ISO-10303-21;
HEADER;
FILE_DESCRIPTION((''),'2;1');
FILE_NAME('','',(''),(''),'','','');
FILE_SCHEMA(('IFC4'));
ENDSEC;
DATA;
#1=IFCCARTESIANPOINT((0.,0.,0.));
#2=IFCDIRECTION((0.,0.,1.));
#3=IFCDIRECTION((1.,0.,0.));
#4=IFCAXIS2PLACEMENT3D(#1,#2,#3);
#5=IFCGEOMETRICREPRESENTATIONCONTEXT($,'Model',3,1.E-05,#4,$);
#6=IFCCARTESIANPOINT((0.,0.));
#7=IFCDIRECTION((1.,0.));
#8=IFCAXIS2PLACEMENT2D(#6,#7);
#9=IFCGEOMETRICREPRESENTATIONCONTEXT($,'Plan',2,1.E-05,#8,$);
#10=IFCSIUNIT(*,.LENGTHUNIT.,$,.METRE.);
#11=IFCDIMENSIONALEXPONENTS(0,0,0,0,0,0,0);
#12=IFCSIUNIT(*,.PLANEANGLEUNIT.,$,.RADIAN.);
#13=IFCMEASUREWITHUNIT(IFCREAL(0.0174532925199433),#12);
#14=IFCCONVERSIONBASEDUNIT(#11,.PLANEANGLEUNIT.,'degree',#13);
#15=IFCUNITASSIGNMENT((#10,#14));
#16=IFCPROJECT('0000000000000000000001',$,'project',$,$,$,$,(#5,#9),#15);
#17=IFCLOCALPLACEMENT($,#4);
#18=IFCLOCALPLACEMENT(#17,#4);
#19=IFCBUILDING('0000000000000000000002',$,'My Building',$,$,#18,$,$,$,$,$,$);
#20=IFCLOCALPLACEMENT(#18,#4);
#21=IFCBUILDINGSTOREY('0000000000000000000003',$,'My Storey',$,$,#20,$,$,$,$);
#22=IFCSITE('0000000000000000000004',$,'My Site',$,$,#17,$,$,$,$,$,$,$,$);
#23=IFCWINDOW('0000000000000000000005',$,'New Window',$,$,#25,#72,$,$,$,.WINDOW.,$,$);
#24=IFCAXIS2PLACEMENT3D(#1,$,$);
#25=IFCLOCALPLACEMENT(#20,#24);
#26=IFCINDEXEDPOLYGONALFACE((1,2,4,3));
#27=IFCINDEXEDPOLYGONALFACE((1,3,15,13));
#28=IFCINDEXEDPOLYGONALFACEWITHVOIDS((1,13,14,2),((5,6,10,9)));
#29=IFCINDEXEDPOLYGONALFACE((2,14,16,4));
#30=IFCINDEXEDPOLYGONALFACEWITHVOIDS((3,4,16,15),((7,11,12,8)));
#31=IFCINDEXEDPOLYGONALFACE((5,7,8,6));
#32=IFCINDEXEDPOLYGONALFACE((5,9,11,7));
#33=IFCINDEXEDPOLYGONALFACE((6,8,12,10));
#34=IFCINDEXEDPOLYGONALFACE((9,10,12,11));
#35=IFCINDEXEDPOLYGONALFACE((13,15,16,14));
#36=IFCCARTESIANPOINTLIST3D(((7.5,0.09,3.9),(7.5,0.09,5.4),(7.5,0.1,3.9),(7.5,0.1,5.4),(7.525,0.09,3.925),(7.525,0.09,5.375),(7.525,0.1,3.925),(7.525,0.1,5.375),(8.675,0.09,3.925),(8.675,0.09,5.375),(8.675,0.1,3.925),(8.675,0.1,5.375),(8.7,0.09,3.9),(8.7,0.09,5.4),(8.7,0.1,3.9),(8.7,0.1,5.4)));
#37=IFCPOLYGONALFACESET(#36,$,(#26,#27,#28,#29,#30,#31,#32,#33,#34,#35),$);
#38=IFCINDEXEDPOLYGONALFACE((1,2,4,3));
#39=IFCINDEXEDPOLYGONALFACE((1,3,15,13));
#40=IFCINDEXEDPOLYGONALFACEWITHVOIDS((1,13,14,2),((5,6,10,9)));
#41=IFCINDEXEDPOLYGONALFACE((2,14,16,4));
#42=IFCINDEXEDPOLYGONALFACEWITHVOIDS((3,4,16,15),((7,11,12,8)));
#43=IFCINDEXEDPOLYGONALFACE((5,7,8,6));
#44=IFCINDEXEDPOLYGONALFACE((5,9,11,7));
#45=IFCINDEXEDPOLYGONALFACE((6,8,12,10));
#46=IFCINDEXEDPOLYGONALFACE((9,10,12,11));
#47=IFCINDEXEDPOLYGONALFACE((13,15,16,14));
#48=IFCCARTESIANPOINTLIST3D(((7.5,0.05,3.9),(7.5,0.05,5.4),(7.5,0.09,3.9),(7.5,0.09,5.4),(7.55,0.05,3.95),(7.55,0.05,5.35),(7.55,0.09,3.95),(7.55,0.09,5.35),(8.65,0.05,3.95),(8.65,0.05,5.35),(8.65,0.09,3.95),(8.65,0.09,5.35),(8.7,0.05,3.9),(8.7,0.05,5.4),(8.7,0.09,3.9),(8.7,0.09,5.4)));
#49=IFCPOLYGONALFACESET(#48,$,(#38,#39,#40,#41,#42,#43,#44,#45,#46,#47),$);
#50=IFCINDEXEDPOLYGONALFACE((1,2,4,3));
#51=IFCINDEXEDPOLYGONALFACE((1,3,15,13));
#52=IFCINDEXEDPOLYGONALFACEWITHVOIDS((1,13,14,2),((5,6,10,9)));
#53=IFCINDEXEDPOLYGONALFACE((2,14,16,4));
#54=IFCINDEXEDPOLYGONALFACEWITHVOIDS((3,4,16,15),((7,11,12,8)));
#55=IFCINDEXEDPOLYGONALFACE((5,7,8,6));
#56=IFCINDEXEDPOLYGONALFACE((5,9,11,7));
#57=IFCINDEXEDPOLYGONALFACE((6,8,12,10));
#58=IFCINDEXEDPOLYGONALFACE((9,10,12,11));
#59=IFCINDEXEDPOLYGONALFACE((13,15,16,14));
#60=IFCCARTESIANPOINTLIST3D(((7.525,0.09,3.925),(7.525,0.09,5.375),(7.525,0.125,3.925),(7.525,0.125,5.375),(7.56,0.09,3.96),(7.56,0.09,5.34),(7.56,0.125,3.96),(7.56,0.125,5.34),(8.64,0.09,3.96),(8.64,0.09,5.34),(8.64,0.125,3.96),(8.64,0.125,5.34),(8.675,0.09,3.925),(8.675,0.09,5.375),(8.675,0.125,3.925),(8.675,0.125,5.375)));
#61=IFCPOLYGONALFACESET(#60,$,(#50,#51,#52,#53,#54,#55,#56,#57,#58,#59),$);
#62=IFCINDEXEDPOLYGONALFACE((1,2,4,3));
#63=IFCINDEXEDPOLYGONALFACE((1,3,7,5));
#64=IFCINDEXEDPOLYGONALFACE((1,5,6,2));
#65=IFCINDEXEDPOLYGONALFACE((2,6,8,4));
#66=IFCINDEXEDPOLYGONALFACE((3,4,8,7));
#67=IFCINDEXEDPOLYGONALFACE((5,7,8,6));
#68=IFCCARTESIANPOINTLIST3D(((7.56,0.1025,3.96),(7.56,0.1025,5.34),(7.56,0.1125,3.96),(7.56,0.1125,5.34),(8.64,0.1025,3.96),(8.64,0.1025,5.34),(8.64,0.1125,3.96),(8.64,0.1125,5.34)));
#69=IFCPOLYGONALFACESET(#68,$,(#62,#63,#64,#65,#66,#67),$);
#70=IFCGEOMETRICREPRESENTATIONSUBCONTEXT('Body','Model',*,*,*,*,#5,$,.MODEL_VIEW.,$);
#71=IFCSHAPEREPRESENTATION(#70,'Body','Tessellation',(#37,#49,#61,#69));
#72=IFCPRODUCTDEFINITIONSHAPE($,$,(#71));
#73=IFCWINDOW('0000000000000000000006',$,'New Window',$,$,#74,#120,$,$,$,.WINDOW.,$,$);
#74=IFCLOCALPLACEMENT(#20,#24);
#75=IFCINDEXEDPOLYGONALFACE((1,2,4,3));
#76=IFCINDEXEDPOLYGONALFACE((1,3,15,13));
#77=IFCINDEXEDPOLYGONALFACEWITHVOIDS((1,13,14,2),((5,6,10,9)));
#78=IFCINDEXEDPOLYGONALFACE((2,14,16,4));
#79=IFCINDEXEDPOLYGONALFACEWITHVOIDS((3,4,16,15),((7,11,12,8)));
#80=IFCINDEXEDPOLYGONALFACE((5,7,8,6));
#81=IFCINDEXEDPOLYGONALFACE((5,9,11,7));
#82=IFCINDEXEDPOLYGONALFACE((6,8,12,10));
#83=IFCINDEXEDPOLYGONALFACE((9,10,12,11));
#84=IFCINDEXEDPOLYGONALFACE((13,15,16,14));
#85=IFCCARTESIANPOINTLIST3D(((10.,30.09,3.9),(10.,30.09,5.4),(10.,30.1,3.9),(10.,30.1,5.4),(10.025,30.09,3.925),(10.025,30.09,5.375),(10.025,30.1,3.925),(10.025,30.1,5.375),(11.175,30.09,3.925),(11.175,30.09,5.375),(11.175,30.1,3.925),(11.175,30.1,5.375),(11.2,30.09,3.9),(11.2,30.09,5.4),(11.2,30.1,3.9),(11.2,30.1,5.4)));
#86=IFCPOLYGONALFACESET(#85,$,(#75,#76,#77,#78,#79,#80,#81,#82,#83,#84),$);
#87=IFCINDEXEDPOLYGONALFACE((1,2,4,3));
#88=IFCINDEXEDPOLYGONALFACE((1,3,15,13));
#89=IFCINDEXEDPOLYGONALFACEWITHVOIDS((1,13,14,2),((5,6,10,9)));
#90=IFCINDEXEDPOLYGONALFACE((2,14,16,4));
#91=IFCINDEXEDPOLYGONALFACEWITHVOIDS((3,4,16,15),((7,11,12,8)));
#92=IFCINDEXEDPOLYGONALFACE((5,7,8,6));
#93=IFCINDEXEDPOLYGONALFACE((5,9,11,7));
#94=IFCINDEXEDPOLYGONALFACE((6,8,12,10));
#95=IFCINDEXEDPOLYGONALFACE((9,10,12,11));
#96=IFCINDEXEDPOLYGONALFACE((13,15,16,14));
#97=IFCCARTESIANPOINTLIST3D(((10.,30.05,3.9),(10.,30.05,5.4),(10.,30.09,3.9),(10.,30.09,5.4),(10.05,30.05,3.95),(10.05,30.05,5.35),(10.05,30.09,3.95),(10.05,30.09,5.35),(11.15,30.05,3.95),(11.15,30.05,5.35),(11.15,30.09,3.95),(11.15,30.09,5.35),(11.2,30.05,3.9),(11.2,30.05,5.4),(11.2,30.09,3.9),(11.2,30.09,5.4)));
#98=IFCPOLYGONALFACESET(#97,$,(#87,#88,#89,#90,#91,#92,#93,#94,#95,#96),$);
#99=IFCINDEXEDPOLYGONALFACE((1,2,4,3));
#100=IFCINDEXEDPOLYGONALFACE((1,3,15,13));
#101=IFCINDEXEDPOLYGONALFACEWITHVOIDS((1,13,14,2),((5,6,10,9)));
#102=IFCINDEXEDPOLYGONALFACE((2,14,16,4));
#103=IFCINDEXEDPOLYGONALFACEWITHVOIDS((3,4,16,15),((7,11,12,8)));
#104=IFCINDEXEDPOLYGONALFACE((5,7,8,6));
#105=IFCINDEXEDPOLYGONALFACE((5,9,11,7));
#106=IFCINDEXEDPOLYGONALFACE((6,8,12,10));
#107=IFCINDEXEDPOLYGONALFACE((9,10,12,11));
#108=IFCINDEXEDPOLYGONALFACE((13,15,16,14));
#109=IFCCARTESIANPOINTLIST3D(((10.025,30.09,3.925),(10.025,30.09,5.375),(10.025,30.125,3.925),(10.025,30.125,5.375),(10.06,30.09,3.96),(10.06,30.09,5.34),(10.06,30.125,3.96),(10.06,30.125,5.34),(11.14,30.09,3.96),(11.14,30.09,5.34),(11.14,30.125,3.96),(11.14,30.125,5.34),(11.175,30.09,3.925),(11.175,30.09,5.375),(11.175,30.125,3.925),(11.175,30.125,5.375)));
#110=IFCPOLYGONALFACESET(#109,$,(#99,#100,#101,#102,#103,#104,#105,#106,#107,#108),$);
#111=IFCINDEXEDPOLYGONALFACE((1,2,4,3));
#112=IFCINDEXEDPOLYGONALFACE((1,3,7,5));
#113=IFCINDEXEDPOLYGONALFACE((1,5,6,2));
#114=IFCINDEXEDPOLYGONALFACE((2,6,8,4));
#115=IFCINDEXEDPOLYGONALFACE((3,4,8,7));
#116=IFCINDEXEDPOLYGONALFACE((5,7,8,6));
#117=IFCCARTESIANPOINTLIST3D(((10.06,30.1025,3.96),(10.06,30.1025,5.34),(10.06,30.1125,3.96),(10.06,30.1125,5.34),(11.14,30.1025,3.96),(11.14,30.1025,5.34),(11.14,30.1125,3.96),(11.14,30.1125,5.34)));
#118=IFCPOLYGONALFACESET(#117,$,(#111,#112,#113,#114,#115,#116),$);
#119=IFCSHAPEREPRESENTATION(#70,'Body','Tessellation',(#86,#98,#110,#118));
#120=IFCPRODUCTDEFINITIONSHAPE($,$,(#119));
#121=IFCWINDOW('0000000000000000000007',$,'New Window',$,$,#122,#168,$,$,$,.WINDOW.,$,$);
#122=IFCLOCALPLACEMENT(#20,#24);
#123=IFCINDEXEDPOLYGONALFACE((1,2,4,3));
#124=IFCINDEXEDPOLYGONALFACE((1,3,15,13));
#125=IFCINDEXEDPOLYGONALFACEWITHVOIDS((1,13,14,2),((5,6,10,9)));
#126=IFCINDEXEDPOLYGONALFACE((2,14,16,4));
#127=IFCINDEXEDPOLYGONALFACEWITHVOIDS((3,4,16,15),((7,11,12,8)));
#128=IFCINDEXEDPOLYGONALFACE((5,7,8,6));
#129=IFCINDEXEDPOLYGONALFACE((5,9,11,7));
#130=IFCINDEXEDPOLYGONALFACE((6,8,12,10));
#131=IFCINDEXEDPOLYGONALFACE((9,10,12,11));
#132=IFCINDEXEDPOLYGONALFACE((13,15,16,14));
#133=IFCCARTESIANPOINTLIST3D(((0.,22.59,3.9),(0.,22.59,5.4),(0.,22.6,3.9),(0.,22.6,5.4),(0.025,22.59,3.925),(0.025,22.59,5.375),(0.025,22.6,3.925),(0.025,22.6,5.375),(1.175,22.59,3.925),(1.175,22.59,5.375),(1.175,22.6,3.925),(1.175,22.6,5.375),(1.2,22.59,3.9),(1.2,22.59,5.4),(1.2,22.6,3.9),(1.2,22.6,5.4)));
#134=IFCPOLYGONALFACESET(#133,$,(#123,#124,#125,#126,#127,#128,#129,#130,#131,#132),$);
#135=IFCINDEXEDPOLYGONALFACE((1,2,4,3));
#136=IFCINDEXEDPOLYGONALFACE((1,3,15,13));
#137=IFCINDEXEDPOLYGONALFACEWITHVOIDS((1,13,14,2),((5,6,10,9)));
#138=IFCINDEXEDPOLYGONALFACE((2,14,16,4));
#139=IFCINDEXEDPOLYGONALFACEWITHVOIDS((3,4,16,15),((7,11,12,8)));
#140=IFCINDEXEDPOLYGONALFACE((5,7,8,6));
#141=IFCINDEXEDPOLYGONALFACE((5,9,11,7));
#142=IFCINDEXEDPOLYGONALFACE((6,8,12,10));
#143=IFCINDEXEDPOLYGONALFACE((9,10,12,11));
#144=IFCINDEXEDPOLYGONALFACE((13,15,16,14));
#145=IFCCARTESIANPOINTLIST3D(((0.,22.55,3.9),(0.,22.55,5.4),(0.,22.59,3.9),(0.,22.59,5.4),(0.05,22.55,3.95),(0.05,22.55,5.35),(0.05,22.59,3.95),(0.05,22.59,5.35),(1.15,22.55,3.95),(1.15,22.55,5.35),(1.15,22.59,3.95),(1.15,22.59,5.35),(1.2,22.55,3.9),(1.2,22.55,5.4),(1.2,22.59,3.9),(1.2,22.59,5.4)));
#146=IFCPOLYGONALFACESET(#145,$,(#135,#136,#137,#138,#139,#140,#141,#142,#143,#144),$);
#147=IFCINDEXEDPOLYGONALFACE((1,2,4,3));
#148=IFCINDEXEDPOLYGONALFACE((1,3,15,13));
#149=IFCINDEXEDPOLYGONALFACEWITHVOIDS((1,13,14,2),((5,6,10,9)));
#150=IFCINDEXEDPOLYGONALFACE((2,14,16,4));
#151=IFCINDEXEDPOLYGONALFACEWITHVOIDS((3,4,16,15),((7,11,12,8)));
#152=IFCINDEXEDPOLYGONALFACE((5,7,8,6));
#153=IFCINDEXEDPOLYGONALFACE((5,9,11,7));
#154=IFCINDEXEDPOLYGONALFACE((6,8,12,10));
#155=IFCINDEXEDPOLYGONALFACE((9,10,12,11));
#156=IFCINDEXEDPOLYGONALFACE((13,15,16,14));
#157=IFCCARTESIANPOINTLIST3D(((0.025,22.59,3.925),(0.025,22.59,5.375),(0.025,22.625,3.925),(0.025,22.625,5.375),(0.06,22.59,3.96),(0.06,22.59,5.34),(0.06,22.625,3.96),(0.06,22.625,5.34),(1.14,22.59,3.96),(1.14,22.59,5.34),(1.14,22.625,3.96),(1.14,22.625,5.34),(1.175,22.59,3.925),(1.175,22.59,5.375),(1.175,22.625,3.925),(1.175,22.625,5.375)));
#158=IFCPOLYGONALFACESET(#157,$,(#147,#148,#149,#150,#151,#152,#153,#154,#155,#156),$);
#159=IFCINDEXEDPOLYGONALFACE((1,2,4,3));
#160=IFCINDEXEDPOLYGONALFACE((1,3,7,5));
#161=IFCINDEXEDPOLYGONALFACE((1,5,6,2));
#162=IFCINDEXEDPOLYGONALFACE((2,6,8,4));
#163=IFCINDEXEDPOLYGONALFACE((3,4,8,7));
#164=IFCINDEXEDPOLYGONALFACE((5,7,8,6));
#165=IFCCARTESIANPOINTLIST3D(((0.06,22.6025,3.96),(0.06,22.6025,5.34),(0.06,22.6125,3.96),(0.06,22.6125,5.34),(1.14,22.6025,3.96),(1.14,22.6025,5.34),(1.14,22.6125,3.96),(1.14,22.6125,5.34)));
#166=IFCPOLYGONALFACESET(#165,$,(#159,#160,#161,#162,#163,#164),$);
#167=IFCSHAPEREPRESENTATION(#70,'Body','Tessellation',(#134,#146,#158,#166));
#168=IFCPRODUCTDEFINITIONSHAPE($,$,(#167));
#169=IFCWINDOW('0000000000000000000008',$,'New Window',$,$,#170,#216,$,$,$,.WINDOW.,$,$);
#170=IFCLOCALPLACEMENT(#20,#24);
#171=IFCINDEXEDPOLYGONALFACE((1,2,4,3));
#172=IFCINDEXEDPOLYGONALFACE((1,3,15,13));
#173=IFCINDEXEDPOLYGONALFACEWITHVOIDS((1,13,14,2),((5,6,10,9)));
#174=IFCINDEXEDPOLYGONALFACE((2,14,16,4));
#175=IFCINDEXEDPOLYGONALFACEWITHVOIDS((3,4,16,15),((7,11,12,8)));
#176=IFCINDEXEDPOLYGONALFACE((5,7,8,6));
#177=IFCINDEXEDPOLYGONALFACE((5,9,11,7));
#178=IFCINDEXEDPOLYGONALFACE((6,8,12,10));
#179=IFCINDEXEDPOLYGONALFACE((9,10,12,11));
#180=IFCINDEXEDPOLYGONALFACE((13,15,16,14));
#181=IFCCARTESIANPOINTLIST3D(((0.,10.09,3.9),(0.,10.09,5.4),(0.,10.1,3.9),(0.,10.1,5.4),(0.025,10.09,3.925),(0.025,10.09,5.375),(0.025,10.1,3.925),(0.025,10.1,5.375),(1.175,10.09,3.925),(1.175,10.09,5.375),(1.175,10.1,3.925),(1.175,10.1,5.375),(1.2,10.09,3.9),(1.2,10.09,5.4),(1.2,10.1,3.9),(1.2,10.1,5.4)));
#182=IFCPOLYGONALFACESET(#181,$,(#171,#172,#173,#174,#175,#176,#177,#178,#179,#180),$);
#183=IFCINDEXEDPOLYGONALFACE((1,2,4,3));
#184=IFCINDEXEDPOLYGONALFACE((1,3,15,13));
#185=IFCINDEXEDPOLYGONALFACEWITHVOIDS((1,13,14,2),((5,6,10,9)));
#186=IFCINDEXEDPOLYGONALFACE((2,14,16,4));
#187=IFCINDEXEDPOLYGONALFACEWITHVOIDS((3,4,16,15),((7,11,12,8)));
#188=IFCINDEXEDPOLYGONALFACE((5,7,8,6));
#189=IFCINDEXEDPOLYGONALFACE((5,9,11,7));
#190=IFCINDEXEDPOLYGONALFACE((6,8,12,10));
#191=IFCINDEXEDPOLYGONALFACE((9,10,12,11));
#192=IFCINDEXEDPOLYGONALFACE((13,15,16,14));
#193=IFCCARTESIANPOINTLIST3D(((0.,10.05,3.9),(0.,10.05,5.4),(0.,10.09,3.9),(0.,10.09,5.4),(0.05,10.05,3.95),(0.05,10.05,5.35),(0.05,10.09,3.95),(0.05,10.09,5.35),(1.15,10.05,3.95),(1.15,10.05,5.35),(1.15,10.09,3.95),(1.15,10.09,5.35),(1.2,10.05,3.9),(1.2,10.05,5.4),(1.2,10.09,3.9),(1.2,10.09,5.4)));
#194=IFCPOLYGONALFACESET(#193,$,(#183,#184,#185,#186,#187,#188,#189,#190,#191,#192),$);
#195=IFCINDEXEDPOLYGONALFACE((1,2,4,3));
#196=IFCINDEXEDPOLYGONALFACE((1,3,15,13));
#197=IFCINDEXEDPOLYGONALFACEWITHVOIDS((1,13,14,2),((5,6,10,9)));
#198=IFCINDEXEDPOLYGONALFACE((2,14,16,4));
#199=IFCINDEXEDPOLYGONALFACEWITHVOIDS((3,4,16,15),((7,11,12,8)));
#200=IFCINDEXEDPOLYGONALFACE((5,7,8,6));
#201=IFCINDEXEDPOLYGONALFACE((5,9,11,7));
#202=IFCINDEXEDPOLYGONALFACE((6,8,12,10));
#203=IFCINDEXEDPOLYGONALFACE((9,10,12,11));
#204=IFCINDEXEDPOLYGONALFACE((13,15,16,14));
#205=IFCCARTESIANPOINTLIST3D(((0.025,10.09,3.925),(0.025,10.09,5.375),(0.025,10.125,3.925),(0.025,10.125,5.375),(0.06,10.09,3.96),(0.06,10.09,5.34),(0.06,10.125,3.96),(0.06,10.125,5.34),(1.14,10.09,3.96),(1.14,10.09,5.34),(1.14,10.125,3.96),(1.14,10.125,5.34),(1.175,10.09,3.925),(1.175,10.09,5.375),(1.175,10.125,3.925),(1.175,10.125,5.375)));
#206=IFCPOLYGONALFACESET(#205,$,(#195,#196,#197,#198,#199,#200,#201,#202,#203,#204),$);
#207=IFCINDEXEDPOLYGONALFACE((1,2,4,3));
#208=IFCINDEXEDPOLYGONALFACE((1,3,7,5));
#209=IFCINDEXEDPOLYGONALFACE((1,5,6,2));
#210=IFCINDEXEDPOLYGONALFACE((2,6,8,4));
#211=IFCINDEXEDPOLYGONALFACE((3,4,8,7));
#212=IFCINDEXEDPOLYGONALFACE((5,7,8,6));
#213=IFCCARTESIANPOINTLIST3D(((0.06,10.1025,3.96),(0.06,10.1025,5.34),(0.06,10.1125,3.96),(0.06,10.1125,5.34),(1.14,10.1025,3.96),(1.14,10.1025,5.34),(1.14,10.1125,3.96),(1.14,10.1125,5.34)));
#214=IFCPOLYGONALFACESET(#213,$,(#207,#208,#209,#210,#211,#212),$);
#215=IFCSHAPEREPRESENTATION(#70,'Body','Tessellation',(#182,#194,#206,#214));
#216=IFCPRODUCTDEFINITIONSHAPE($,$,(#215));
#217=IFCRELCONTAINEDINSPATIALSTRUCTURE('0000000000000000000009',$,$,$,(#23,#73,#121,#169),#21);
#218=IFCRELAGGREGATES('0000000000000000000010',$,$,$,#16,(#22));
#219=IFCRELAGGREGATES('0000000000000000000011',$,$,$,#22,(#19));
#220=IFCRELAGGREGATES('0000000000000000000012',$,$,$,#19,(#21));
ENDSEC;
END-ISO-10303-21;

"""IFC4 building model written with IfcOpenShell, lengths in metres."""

from ifc_helpers import new_model, entity, si_unit, converted_unit, frame, origin_with_axes, origin_2d_with_axis, place, context, subcontext, project, spatial, line, indexed_curve, outline, extrude, element, save


model = new_model("IFC4")

# Units and contexts
model_context = context("Model", 3, precision=1e-05, world=origin_with_axes())
plan_context = context("Plan", 2, precision=1e-05, world=origin_2d_with_axis())
body_context = subcontext(model_context, "Body", "Model", "MODEL_VIEW")
ifc_project = project(units=[si_unit("LENGTHUNIT", "METRE"), converted_unit("PLANEANGLEUNIT", "degree", entity("IfcReal", 0.0174532925199433), si_unit("PLANEANGLEUNIT", "RADIAN"), dimensions=[0, 0, 0, 0, 0, 0, 0])], contexts=[model_context, plan_context])

# Site, building, storey
site_placement = place(None, origin_with_axes())
site = spatial("IfcSite", under=ifc_project, at=site_placement, Name="My Site")
building_placement = place(site_placement, origin_with_axes())
building = spatial("IfcBuilding", under=site, at=building_placement, Name="My Building")
storey_placement = place(building_placement, origin_with_axes())
storey = spatial("IfcBuildingStorey", under=building, at=storey_placement, Name="My Storey")

# Windows
for number, where, z_axis, x_axis, name in (
    (1, (7.5, 0.0, 3.9), (0.0, 0.0, 1.0), (1.0, 0.0, 0.0), "New Window"),
    (2, (10.0, 30.0, 3.9), (0.0, 0.0, 1.0), (1.0, 0.0, 0.0), "New Window"),
    (3, (0.0, 22.5, 3.9), (0.0, 0.0, 1.0), (1.0, 0.0, 0.0), "New Window"),
    (4, (0.0, 10.0, 3.9), (0.0, 0.0, 1.0), (1.0, 0.0, 0.0), "New Window"),
):
    element("IfcWindow", number, at=place(storey_placement, frame(where, z_axis=z_axis, x_axis=x_axis)), inside=storey, Name=name, PredefinedType="WINDOW", context=body_context, shape_type="SweptSolid", body=[
        extrude(outline(indexed_curve([(0.0, 0.0), (1.2, 0.0), (1.2, 1.5), (0.0, 1.5)], segments=[line(1, 2, 3, 4, 1)]), holes=[indexed_curve([(0.025, 0.025), (1.175, 0.025), (1.175, 1.475), (0.025, 1.475)], segments=[line(1, 2, 3, 4, 1)])]), frame((0.0, 0.09, 0.0), z_axis=(0.0, -1.0, 0.0), x_axis=(1.0, 0.0, 0.0)), (0.0, 0.0, -1.0), 0.01),
        extrude(outline(indexed_curve([(0.0, 0.0), (1.2, 0.0), (1.2, 1.5), (0.0, 1.5)], segments=[line(1, 2, 3, 4, 1)]), holes=[indexed_curve([(0.05, 0.05), (1.15, 0.05), (1.15, 1.45), (0.05, 1.45)], segments=[line(1, 2, 3, 4, 1)])]), frame((0.0, 0.05, 0.0), z_axis=(0.0, -1.0, 0.0), x_axis=(1.0, 0.0, 0.0)), (0.0, 0.0, -1.0), 0.04),
        extrude(outline(indexed_curve([(0.0, 0.0), (1.15, 0.0), (1.15, 1.45), (0.0, 1.45)], segments=[line(1, 2, 3, 4, 1)]), holes=[indexed_curve([(0.035, 0.035), (1.115, 0.035), (1.115, 1.415), (0.035, 1.415)], segments=[line(1, 2, 3, 4, 1)])]), frame((0.025, 0.09, 0.025), z_axis=(0.0, -1.0, 0.0), x_axis=(1.0, 0.0, 0.0)), (0.0, 0.0, -1.0), 0.035),
        extrude(outline(indexed_curve([(0.035, 0.035), (1.115, 0.035), (1.115, 1.415), (0.035, 1.415)], segments=[line(1, 2, 3, 4, 1)])), frame((0.025, 0.1025, 0.025), z_axis=(0.0, -1.0, 0.0), x_axis=(1.0, 0.0, 0.0)), (0.0, 0.0, -1.0), 0.01),
    ])

save(model, "model.ifc")
